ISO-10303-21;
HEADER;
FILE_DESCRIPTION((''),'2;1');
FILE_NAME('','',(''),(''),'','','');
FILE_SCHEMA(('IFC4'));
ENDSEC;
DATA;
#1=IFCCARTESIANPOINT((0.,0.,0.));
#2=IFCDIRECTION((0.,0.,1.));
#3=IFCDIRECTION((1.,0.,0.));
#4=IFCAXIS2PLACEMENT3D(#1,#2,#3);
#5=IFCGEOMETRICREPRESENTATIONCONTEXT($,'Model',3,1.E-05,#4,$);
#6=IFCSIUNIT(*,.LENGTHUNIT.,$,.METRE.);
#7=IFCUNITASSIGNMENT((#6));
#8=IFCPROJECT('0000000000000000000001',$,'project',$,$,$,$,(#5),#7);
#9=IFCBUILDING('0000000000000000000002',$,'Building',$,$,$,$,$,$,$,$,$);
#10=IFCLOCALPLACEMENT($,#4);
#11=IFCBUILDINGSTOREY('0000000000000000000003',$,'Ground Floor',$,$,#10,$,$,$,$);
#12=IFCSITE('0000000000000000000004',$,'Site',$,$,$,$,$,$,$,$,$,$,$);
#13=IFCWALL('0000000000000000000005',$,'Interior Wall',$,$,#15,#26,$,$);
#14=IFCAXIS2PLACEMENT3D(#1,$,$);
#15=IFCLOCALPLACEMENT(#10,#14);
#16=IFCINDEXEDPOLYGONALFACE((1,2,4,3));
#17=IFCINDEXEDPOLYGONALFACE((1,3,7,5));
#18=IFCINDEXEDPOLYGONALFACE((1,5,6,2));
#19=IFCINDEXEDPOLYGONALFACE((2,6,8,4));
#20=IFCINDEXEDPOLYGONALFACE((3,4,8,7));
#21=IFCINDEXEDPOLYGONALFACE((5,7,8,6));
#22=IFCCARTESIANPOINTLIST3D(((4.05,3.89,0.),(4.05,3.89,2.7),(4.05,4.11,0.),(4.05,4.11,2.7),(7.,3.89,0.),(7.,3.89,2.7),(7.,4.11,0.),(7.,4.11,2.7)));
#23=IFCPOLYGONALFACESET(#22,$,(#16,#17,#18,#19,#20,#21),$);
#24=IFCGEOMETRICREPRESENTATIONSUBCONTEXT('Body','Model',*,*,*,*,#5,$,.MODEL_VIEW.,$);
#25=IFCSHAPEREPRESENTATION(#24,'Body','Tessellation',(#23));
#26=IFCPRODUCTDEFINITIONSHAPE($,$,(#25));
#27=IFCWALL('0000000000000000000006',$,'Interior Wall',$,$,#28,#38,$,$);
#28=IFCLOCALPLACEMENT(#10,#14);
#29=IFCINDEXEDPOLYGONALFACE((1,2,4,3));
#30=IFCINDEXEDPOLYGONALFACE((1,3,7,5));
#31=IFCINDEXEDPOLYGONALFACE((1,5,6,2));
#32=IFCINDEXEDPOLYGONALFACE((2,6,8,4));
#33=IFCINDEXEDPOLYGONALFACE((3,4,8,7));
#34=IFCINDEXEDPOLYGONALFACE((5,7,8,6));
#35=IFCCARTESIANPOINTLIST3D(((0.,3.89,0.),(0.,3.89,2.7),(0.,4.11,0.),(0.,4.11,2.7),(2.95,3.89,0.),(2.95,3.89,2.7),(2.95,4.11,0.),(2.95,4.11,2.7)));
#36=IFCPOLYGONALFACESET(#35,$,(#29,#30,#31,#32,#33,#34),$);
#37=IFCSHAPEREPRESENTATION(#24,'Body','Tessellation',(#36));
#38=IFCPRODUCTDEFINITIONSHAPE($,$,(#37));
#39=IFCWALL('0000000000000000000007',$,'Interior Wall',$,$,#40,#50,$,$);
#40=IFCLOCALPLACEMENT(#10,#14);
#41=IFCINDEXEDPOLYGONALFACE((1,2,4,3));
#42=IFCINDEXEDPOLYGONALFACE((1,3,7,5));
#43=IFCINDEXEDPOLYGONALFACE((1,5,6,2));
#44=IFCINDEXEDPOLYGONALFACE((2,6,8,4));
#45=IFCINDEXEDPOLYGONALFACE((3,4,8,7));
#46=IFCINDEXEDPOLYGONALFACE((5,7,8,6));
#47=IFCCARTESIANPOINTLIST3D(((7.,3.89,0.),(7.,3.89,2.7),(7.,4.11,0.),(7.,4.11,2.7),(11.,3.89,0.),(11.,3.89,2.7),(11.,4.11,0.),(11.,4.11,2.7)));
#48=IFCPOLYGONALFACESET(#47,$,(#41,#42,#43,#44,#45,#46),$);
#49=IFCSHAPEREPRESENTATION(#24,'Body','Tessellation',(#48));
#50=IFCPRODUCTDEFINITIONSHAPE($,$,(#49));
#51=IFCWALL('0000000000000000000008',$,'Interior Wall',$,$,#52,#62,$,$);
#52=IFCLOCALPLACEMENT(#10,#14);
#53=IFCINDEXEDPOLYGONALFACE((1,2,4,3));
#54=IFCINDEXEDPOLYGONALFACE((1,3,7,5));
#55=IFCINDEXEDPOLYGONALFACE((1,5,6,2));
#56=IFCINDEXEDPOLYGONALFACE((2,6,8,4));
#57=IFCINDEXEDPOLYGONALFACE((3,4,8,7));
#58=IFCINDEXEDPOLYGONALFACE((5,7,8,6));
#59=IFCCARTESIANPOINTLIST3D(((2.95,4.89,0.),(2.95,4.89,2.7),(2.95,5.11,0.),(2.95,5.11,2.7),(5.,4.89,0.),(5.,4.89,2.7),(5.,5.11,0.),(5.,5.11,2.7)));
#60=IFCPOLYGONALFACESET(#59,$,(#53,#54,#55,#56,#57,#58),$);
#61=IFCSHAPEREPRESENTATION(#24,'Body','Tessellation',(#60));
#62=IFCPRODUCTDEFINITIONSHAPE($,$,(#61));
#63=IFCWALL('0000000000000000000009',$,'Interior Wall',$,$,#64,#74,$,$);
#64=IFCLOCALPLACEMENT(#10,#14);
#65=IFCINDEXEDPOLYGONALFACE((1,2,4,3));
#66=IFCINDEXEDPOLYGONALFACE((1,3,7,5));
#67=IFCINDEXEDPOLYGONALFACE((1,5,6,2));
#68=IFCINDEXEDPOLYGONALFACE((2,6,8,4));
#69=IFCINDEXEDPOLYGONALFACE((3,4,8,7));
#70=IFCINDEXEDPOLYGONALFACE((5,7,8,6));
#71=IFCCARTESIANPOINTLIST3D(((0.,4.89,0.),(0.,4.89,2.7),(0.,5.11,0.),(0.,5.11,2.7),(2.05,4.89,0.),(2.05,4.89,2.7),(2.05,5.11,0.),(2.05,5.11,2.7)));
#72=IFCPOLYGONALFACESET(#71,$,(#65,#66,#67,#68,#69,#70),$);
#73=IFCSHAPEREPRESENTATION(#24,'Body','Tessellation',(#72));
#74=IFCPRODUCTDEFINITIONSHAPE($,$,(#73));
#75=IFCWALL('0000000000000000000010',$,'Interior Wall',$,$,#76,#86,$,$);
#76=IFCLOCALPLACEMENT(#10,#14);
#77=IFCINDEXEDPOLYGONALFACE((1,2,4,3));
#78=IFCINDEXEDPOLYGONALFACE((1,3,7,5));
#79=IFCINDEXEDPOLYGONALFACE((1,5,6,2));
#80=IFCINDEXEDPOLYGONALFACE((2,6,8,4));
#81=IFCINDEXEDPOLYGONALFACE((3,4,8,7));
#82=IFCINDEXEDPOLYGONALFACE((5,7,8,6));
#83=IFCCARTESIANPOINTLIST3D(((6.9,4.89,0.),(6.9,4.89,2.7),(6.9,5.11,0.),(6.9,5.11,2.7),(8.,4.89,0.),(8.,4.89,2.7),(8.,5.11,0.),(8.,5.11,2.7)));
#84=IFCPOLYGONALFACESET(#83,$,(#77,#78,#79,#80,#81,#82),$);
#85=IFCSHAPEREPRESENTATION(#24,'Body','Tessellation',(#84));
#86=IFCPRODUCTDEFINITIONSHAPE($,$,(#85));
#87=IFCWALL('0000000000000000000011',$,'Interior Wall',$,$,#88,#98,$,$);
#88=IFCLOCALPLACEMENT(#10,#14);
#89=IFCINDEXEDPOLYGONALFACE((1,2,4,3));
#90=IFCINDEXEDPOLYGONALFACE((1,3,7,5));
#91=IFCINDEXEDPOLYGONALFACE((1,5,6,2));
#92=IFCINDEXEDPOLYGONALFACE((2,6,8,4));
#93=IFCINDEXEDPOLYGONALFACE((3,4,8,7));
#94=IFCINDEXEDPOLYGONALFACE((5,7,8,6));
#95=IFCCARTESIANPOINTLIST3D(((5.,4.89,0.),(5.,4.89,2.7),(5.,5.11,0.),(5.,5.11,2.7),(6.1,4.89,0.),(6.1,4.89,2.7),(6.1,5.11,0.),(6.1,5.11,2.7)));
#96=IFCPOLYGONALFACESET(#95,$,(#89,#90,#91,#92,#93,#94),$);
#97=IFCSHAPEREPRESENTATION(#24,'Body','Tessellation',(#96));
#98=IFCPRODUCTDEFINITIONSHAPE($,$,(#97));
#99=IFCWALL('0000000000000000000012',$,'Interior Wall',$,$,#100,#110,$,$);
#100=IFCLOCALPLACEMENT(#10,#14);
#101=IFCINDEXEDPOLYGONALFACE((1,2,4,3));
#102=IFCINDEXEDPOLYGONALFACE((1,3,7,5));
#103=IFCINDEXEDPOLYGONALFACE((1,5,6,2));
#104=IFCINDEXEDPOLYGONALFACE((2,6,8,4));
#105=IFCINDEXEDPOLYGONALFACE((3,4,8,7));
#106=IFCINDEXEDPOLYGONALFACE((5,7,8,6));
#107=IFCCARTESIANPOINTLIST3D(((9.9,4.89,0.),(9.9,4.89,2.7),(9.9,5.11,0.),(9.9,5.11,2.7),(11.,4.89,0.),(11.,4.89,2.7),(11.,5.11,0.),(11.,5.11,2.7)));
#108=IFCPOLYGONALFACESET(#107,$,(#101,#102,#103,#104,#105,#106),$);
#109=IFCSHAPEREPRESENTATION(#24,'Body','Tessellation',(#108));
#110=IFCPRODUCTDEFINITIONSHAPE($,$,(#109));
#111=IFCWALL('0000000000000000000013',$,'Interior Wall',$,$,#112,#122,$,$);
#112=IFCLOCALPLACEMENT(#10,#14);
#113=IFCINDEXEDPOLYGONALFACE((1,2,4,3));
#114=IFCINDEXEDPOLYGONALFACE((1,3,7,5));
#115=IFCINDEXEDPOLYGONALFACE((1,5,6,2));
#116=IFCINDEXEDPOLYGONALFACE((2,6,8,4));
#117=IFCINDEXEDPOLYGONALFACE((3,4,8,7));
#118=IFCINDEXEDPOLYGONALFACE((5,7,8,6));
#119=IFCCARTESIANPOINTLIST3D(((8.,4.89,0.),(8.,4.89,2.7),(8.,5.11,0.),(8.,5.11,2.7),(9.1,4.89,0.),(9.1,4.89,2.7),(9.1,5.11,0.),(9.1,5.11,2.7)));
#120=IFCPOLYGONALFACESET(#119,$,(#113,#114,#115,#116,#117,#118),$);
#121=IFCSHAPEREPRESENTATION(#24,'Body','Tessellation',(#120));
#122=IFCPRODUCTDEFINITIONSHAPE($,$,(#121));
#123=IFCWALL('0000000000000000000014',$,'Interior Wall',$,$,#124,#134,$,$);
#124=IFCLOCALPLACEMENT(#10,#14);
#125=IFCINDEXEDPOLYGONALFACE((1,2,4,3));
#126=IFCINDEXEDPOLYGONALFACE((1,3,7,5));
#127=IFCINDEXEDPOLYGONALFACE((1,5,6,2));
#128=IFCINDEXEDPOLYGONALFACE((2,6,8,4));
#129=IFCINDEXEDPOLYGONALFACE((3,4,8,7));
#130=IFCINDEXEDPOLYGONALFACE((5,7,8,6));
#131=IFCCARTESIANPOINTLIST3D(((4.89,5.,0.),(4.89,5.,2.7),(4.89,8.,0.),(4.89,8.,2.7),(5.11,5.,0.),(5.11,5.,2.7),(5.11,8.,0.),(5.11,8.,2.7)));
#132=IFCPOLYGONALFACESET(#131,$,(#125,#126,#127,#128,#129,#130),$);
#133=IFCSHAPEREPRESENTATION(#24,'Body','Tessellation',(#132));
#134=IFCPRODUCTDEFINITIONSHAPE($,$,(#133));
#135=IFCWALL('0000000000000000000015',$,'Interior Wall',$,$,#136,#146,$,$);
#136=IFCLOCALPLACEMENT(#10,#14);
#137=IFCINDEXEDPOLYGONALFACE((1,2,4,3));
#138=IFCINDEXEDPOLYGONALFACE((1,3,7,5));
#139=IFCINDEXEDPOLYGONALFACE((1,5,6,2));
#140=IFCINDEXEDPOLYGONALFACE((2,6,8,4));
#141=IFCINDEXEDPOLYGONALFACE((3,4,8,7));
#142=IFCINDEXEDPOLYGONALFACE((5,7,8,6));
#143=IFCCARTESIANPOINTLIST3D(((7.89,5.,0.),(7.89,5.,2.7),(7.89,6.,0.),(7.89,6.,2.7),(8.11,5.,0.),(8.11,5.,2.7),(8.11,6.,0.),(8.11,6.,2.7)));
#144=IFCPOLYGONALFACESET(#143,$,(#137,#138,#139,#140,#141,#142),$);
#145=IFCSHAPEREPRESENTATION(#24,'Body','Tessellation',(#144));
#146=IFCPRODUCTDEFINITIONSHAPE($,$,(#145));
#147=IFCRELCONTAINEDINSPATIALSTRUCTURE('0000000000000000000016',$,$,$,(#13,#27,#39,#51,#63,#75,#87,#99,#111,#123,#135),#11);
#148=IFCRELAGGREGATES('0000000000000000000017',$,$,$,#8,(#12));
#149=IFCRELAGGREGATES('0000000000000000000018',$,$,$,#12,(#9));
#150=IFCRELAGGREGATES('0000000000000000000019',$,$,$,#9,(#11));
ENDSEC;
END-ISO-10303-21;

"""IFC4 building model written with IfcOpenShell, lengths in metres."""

from ifc_helpers import new_model, si_unit, frame, origin_with_axes, place, context, subcontext, project, spatial, indexed_curve, outline, extrude, element, save


model = new_model("IFC4")

# Units and contexts
model_context = context("Model", 3, precision=1e-05, world=origin_with_axes())
body_context = subcontext(model_context, "Body", "Model", "MODEL_VIEW")
ifc_project = project(units=[si_unit("LENGTHUNIT", "METRE")], contexts=[model_context])

# Site, building, storey
site = spatial("IfcSite", under=ifc_project, Name="Site")
building = spatial("IfcBuilding", under=site, Name="Building")
storey_placement = place(None, origin_with_axes())
storey = spatial("IfcBuildingStorey", under=building, at=storey_placement, Name="Ground Floor")

# Walls
for number, where, z_axis, x_axis, name in (
    (1, (7.0, 4.0, 0.0), (0.0, 0.0, 1.0), (-1.0, 0.0, 0.0), "Interior Wall"),
    (2, (2.95, 4.0, 0.0), (0.0, 0.0, 1.0), (-1.0, 0.0, 0.0), "Interior Wall"),
):
    element("IfcWall", number, at=place(storey_placement, frame(where, z_axis=z_axis, x_axis=x_axis)), inside=storey, Name=name, context=body_context, shape_type="SweptSolid", body=[
        extrude(outline(indexed_curve([(0.0, 0.0), (0.0, 0.22), (2.95, 0.22), (2.95, 0.0), (0.0, 0.0)], self_intersect=False)), frame((0.0, -0.11, 0.0), z_axis=(0.0, 0.0, 1.0), x_axis=(1.0, 0.0, 0.0)), (0.0, 0.0, 1.0), 2.7),
    ])
wall_1_placement = place(storey_placement, frame((11.0, 4.0, 0.0), z_axis=(0.0, 0.0, 1.0), x_axis=(-1.0, 0.0, 0.0)))
element("IfcWall", 3, at=wall_1_placement, inside=storey, Name="Interior Wall", context=body_context, shape_type="SweptSolid", body=[
    extrude(outline(indexed_curve([(0.0, 0.0), (0.0, 0.22), (4.0, 0.22), (4.0, 0.0), (0.0, 0.0)], self_intersect=False)), frame((0.0, -0.11, 0.0), z_axis=(0.0, 0.0, 1.0), x_axis=(1.0, 0.0, 0.0)), (0.0, 0.0, 1.0), 2.7),
])
for number, where, z_axis, x_axis, name in (
    (4, (5.0, 5.0, 0.0), (0.0, 0.0, 1.0), (-1.0, 0.0, 0.0), "Interior Wall"),
    (5, (2.05, 5.0, 0.0), (0.0, 0.0, 1.0), (-1.0, 0.0, 0.0), "Interior Wall"),
):
    element("IfcWall", number, at=place(storey_placement, frame(where, z_axis=z_axis, x_axis=x_axis)), inside=storey, Name=name, context=body_context, shape_type="SweptSolid", body=[
        extrude(outline(indexed_curve([(0.0, 0.0), (0.0, 0.22), (2.05, 0.22), (2.05, 0.0), (0.0, 0.0)], self_intersect=False)), frame((0.0, -0.11, 0.0), z_axis=(0.0, 0.0, 1.0), x_axis=(1.0, 0.0, 0.0)), (0.0, 0.0, 1.0), 2.7),
    ])
for number, where, z_axis, x_axis, name in (
    (6, (8.0, 5.0, 0.0), (0.0, 0.0, 1.0), (-1.0, 0.0, 0.0), "Interior Wall"),
    (7, (6.1, 5.0, 0.0), (0.0, 0.0, 1.0), (-1.0, 0.0, 0.0), "Interior Wall"),
    (8, (11.0, 5.0, 0.0), (0.0, 0.0, 1.0), (-1.0, 0.0, 0.0), "Interior Wall"),
    (9, (9.1, 5.0, 0.0), (0.0, 0.0, 1.0), (-1.0, 0.0, 0.0), "Interior Wall"),
):
    element("IfcWall", number, at=place(storey_placement, frame(where, z_axis=z_axis, x_axis=x_axis)), inside=storey, Name=name, context=body_context, shape_type="SweptSolid", body=[
        extrude(outline(indexed_curve([(0.0, 0.0), (0.0, 0.22), (1.1, 0.22), (1.1, 0.0), (0.0, 0.0)], self_intersect=False)), frame((0.0, -0.11, 0.0), z_axis=(0.0, 0.0, 1.0), x_axis=(1.0, 0.0, 0.0)), (0.0, 0.0, 1.0), 2.7),
    ])
wall_2_placement = place(storey_placement, frame((5.0, 5.0, 0.0), z_axis=(0.0, 0.0, 1.0), x_axis=(0.0, 1.0, 0.0)))
element("IfcWall", 10, at=wall_2_placement, inside=storey, Name="Interior Wall", context=body_context, shape_type="SweptSolid", body=[
    extrude(outline(indexed_curve([(0.0, 0.0), (0.0, 0.22), (3.0, 0.22), (3.0, 0.0), (0.0, 0.0)], self_intersect=False)), frame((0.0, -0.11, 0.0), z_axis=(0.0, 0.0, 1.0), x_axis=(1.0, 0.0, 0.0)), (0.0, 0.0, 1.0), 2.7),
])
wall_3_placement = place(storey_placement, frame((8.0, 5.0, 0.0), z_axis=(0.0, 0.0, 1.0), x_axis=(0.0, 1.0, 0.0)))
element("IfcWall", 11, at=wall_3_placement, inside=storey, Name="Interior Wall", context=body_context, shape_type="SweptSolid", body=[
    extrude(outline(indexed_curve([(0.0, 0.0), (0.0, 0.22), (1.0, 0.22), (1.0, 0.0), (0.0, 0.0)], self_intersect=False)), frame((0.0, -0.11, 0.0), z_axis=(0.0, 0.0, 1.0), x_axis=(1.0, 0.0, 0.0)), (0.0, 0.0, 1.0), 2.7),
])

save(model, "model.ifc")
